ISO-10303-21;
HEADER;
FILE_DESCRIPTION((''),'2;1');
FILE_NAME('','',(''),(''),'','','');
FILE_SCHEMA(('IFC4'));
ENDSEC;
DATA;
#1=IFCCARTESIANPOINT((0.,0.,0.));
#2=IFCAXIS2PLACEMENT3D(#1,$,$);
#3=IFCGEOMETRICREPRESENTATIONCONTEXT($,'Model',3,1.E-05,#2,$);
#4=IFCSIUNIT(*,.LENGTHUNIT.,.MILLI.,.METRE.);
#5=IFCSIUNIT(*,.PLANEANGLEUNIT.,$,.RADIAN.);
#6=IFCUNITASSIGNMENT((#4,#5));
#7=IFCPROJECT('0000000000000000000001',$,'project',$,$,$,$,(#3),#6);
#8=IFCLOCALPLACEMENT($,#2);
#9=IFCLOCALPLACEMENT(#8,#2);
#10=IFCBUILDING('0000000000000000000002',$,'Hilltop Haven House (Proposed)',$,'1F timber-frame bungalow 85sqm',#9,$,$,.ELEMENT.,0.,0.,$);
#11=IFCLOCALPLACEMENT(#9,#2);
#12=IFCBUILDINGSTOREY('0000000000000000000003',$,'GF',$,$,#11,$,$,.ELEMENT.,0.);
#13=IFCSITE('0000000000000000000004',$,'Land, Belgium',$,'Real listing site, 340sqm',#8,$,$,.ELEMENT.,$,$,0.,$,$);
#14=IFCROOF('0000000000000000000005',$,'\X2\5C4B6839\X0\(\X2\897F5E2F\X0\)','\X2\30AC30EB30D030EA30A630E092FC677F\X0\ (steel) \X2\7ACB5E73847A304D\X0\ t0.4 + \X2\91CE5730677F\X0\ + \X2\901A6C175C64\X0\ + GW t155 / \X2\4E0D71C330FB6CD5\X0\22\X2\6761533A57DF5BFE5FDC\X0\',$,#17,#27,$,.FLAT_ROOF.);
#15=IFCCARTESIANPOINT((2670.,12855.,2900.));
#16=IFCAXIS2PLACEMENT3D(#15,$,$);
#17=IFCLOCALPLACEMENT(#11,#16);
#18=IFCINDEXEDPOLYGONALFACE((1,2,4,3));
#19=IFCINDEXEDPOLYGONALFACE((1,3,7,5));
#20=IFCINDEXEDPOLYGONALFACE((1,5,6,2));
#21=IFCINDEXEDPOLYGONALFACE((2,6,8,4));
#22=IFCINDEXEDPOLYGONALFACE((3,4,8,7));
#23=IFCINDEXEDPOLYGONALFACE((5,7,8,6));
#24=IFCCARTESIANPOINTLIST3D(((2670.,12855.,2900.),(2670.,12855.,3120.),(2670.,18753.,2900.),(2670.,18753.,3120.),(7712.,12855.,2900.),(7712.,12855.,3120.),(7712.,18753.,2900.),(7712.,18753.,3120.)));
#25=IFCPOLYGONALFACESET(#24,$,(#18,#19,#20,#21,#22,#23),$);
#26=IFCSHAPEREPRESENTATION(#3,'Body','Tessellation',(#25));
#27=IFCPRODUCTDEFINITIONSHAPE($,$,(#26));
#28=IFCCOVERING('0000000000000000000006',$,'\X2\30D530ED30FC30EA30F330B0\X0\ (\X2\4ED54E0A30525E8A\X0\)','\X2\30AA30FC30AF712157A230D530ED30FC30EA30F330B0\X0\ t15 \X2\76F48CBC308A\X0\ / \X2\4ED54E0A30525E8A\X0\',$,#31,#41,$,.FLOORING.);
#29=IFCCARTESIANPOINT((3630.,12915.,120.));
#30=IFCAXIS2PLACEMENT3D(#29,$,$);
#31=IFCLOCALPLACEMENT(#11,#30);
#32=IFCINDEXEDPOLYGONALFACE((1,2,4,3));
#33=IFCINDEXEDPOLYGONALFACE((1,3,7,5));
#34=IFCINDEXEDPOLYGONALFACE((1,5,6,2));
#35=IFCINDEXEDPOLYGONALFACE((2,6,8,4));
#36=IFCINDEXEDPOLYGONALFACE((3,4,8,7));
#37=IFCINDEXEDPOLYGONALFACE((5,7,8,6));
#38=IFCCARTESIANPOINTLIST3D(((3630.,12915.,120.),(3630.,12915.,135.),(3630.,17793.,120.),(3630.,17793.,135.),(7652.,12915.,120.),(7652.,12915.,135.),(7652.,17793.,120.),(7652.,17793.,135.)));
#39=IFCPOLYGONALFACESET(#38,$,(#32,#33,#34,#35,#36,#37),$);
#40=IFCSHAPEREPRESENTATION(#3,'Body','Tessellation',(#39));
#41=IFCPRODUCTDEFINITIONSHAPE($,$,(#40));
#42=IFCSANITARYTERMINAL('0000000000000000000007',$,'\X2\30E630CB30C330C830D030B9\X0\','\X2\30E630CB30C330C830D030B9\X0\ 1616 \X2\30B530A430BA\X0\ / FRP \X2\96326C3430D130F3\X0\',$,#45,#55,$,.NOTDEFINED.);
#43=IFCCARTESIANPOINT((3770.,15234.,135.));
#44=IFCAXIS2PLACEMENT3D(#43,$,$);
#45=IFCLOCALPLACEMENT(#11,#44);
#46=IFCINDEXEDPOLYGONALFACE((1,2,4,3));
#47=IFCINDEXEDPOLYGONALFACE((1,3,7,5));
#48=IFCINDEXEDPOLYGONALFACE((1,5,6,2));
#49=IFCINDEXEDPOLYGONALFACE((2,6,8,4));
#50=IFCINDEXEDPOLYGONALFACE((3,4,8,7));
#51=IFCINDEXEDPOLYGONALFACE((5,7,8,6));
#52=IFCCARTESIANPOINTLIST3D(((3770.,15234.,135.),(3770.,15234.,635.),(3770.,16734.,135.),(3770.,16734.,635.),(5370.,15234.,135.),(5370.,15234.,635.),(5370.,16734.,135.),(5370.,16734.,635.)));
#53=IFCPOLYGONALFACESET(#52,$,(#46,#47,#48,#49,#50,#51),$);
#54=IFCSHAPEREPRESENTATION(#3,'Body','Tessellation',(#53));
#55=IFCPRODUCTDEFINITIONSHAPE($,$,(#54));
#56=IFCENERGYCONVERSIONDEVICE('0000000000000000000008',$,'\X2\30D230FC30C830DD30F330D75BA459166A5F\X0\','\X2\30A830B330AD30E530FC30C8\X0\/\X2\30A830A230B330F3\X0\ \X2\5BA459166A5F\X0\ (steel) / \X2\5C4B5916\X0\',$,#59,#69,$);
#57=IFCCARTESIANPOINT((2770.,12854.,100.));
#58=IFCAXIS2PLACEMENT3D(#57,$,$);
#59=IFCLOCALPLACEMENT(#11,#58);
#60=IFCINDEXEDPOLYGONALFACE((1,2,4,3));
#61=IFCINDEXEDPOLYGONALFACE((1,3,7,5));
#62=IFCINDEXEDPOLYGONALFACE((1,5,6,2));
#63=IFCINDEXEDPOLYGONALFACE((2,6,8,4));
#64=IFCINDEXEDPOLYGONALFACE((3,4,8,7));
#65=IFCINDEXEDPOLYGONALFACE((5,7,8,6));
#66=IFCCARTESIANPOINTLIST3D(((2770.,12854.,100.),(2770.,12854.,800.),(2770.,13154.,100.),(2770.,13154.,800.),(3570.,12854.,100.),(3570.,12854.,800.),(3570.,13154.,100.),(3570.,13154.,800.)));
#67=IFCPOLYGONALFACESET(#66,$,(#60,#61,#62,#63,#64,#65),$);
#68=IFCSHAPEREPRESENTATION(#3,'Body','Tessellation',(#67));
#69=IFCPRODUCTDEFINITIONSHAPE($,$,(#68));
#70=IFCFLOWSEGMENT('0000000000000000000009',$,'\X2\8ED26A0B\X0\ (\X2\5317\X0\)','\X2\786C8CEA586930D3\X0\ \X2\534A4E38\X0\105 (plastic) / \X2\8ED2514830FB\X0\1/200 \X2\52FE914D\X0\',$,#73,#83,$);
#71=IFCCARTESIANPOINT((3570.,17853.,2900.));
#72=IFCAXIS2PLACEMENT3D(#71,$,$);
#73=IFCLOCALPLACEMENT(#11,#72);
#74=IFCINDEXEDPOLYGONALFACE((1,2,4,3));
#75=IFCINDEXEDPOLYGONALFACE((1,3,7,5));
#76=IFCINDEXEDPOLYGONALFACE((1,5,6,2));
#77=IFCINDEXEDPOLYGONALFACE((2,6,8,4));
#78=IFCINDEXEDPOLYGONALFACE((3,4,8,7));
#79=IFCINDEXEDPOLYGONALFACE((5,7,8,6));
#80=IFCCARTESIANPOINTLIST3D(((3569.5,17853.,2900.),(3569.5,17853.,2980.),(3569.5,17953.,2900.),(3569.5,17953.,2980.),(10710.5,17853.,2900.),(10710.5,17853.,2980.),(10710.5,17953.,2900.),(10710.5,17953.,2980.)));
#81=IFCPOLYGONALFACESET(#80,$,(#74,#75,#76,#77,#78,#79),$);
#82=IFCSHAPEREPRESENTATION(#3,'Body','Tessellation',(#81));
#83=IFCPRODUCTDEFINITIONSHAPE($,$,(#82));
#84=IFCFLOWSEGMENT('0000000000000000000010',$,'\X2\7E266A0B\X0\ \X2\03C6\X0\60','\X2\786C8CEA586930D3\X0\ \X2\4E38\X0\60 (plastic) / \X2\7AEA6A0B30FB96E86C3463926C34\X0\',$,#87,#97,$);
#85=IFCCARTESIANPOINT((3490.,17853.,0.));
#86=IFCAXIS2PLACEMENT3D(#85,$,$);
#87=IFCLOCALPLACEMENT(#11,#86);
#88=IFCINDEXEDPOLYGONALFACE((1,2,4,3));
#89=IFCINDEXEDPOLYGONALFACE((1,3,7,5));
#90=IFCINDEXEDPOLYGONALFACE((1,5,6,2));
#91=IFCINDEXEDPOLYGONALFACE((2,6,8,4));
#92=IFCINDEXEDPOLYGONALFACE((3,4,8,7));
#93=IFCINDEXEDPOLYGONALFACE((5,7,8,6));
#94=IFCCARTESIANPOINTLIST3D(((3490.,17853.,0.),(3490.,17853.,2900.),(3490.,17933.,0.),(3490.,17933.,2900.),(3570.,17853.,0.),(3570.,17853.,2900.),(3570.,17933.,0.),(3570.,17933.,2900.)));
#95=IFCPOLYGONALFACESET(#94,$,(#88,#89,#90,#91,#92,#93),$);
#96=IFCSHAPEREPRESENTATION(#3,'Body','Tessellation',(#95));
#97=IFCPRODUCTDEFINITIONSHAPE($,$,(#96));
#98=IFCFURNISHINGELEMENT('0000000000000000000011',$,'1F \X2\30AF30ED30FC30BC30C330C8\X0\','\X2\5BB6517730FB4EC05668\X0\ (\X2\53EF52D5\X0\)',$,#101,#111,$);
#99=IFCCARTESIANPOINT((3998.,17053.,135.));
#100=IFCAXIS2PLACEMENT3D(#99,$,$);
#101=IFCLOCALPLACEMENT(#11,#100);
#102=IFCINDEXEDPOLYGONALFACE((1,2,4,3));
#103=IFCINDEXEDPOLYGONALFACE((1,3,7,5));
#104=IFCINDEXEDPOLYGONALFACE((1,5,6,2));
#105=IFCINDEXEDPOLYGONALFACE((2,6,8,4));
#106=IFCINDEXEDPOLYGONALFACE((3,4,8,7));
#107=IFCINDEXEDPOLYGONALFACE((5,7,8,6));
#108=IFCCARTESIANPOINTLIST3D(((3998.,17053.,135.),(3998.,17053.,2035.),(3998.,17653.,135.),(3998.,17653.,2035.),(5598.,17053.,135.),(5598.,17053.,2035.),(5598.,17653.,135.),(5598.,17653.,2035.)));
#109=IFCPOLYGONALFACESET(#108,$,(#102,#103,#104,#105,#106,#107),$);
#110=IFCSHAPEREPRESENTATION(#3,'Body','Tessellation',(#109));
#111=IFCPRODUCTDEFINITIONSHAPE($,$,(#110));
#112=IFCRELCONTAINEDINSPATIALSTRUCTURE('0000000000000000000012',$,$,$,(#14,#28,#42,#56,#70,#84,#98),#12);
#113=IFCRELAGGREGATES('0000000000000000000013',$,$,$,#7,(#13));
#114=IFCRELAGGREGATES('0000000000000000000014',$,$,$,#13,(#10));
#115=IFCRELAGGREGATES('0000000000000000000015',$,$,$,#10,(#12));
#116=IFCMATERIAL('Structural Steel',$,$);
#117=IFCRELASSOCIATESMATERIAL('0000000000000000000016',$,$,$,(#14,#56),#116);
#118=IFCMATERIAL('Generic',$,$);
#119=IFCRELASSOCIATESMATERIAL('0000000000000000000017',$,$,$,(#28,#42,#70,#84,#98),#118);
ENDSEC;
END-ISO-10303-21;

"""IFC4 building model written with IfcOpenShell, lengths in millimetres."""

from ifc_helpers import new_model, si_unit, frame, frame_2d, origin, place, context, project, spatial, rectangle, extrude, material, element, save


model = new_model("IFC4")

# Units and contexts
model_context = context("Model", 3, precision=1e-05, world=origin())
ifc_project = project(units=[si_unit("LENGTHUNIT", "METRE", prefix="MILLI"), si_unit("PLANEANGLEUNIT", "RADIAN")], contexts=[model_context])

# Site, building, storey
site_placement = place(None, origin())
site = spatial("IfcSite", under=ifc_project, at=site_placement, Name="Land, Belgium", ObjectType="Real listing site, 340sqm", CompositionType="ELEMENT", RefElevation=0.0)
building_placement = place(site_placement, origin())
building = spatial("IfcBuilding", under=site, at=building_placement, Name="Hilltop Haven House (Proposed)", ObjectType="1F timber-frame bungalow 85sqm", CompositionType="ELEMENT", ElevationOfRefHeight=0.0, ElevationOfTerrain=0.0)
storey_placement = place(building_placement, origin())
storey = spatial("IfcBuildingStorey", under=building, at=storey_placement, Name="GF", CompositionType="ELEMENT", Elevation=0.0)

# Roof
ifc_material_1 = material(Name="Structural Steel")
roof_placement = place(storey_placement, frame((2670.0, 12855.0, 2900.0)))
element("IfcRoof", 1, at=roof_placement, inside=storey, material=ifc_material_1, Name="屋根(西帯)", Description="ガルバリウム鋼板 (steel) 立平葺き t0.4 + 野地板 + 通気層 + GW t155 / 不燃・法22条区域対応", PredefinedType="FLAT_ROOF", context=model_context, shape_type="SweptSolid", body=[
    extrude(rectangle(XDim=5042.0, YDim=5898.0, at=frame_2d((2521.0, 2949.0))), frame((2670.0, 12855.0, 2900.0)), (0.0, 0.0, 1.0), 220.0),
])

# Covering
ifc_material_2 = material(Name="Generic")
covering_placement = place(storey_placement, frame((3630.0, 12915.0, 120.0)))
element("IfcCovering", 2, at=covering_placement, inside=storey, material=ifc_material_2, Name="フローリング (仕上げ床)", Description="オーク無垢フローリング t15 直貼り / 仕上げ床", PredefinedType="FLOORING", context=model_context, shape_type="SweptSolid", body=[
    extrude(rectangle(XDim=4022.0, YDim=4878.0, at=frame_2d((2011.0, 2439.0))), frame((3630.0, 12915.0, 120.0)), (0.0, 0.0, 1.0), 15.0),
])

# Sanitary terminal
sanitary_terminal_placement = place(storey_placement, frame((3770.0, 15234.0, 135.0)))
element("IfcSanitaryTerminal", 3, at=sanitary_terminal_placement, inside=storey, material=ifc_material_2, Name="ユニットバス", Description="ユニットバス 1616 サイズ / FRP 防水パン", PredefinedType="NOTDEFINED", context=model_context, shape_type="SweptSolid", body=[
    extrude(rectangle(XDim=1600.0, YDim=1500.0, at=frame_2d((800.0, 750.0))), frame((3770.0, 15234.0, 135.0)), (0.0, 0.0, 1.0), 500.0),
])

# Energy conversion device
energy_conversion_device_placement = place(storey_placement, frame((2770.0, 12854.0, 100.0)))
element("IfcEnergyConversionDevice", 4, at=energy_conversion_device_placement, inside=storey, material=ifc_material_1, Name="ヒートポンプ室外機", Description="エコキュート/エアコン 室外機 (steel) / 屋外", context=model_context, shape_type="SweptSolid", body=[
    extrude(rectangle(XDim=800.0, YDim=300.0, at=frame_2d((400.0, 150.0))), frame((2770.0, 12854.0, 100.0)), (0.0, 0.0, 1.0), 700.0),
])

# Flow segments
flow_segment_1_placement = place(storey_placement, frame((3570.0, 17853.0, 2900.0)))
element("IfcFlowSegment", 5, at=flow_segment_1_placement, inside=storey, material=ifc_material_2, Name="軒樋 (北)", Description="硬質塩ビ 半丸105 (plastic) / 軒先・1/200 勾配", context=model_context, shape_type="SweptSolid", body=[
    extrude(rectangle(XDim=7141.0, YDim=100.0, at=frame_2d((3570.0, 50.0))), frame((3570.0, 17853.0, 2900.0)), (0.0, 0.0, 1.0), 80.0),
])
flow_segment_2_placement = place(storey_placement, frame((3490.0, 17853.0, 0.0)))
element("IfcFlowSegment", 6, at=flow_segment_2_placement, inside=storey, material=ifc_material_2, Name="縦樋 φ60", Description="硬質塩ビ 丸60 (plastic) / 竪樋・雨水排水", context=model_context, shape_type="SweptSolid", body=[
    extrude(rectangle(XDim=80.0, YDim=80.0, at=frame_2d((40.0, 40.0))), frame((3490.0, 17853.0, 0.0)), (0.0, 0.0, 1.0), 2900.0),
])

# Furnishing element
furnishing_placement = place(storey_placement, frame((3998.0, 17053.0, 135.0)))
element("IfcFurnishingElement", 7, at=furnishing_placement, inside=storey, material=ifc_material_2, Name="1F クローゼット", Description="家具・什器 (可動)", context=model_context, shape_type="SweptSolid", body=[
    extrude(rectangle(XDim=1600.0, YDim=600.0, at=frame_2d((800.0, 300.0))), frame((3998.0, 17053.0, 135.0)), (0.0, 0.0, 1.0), 1900.0),
])

save(model, "model.ifc")
